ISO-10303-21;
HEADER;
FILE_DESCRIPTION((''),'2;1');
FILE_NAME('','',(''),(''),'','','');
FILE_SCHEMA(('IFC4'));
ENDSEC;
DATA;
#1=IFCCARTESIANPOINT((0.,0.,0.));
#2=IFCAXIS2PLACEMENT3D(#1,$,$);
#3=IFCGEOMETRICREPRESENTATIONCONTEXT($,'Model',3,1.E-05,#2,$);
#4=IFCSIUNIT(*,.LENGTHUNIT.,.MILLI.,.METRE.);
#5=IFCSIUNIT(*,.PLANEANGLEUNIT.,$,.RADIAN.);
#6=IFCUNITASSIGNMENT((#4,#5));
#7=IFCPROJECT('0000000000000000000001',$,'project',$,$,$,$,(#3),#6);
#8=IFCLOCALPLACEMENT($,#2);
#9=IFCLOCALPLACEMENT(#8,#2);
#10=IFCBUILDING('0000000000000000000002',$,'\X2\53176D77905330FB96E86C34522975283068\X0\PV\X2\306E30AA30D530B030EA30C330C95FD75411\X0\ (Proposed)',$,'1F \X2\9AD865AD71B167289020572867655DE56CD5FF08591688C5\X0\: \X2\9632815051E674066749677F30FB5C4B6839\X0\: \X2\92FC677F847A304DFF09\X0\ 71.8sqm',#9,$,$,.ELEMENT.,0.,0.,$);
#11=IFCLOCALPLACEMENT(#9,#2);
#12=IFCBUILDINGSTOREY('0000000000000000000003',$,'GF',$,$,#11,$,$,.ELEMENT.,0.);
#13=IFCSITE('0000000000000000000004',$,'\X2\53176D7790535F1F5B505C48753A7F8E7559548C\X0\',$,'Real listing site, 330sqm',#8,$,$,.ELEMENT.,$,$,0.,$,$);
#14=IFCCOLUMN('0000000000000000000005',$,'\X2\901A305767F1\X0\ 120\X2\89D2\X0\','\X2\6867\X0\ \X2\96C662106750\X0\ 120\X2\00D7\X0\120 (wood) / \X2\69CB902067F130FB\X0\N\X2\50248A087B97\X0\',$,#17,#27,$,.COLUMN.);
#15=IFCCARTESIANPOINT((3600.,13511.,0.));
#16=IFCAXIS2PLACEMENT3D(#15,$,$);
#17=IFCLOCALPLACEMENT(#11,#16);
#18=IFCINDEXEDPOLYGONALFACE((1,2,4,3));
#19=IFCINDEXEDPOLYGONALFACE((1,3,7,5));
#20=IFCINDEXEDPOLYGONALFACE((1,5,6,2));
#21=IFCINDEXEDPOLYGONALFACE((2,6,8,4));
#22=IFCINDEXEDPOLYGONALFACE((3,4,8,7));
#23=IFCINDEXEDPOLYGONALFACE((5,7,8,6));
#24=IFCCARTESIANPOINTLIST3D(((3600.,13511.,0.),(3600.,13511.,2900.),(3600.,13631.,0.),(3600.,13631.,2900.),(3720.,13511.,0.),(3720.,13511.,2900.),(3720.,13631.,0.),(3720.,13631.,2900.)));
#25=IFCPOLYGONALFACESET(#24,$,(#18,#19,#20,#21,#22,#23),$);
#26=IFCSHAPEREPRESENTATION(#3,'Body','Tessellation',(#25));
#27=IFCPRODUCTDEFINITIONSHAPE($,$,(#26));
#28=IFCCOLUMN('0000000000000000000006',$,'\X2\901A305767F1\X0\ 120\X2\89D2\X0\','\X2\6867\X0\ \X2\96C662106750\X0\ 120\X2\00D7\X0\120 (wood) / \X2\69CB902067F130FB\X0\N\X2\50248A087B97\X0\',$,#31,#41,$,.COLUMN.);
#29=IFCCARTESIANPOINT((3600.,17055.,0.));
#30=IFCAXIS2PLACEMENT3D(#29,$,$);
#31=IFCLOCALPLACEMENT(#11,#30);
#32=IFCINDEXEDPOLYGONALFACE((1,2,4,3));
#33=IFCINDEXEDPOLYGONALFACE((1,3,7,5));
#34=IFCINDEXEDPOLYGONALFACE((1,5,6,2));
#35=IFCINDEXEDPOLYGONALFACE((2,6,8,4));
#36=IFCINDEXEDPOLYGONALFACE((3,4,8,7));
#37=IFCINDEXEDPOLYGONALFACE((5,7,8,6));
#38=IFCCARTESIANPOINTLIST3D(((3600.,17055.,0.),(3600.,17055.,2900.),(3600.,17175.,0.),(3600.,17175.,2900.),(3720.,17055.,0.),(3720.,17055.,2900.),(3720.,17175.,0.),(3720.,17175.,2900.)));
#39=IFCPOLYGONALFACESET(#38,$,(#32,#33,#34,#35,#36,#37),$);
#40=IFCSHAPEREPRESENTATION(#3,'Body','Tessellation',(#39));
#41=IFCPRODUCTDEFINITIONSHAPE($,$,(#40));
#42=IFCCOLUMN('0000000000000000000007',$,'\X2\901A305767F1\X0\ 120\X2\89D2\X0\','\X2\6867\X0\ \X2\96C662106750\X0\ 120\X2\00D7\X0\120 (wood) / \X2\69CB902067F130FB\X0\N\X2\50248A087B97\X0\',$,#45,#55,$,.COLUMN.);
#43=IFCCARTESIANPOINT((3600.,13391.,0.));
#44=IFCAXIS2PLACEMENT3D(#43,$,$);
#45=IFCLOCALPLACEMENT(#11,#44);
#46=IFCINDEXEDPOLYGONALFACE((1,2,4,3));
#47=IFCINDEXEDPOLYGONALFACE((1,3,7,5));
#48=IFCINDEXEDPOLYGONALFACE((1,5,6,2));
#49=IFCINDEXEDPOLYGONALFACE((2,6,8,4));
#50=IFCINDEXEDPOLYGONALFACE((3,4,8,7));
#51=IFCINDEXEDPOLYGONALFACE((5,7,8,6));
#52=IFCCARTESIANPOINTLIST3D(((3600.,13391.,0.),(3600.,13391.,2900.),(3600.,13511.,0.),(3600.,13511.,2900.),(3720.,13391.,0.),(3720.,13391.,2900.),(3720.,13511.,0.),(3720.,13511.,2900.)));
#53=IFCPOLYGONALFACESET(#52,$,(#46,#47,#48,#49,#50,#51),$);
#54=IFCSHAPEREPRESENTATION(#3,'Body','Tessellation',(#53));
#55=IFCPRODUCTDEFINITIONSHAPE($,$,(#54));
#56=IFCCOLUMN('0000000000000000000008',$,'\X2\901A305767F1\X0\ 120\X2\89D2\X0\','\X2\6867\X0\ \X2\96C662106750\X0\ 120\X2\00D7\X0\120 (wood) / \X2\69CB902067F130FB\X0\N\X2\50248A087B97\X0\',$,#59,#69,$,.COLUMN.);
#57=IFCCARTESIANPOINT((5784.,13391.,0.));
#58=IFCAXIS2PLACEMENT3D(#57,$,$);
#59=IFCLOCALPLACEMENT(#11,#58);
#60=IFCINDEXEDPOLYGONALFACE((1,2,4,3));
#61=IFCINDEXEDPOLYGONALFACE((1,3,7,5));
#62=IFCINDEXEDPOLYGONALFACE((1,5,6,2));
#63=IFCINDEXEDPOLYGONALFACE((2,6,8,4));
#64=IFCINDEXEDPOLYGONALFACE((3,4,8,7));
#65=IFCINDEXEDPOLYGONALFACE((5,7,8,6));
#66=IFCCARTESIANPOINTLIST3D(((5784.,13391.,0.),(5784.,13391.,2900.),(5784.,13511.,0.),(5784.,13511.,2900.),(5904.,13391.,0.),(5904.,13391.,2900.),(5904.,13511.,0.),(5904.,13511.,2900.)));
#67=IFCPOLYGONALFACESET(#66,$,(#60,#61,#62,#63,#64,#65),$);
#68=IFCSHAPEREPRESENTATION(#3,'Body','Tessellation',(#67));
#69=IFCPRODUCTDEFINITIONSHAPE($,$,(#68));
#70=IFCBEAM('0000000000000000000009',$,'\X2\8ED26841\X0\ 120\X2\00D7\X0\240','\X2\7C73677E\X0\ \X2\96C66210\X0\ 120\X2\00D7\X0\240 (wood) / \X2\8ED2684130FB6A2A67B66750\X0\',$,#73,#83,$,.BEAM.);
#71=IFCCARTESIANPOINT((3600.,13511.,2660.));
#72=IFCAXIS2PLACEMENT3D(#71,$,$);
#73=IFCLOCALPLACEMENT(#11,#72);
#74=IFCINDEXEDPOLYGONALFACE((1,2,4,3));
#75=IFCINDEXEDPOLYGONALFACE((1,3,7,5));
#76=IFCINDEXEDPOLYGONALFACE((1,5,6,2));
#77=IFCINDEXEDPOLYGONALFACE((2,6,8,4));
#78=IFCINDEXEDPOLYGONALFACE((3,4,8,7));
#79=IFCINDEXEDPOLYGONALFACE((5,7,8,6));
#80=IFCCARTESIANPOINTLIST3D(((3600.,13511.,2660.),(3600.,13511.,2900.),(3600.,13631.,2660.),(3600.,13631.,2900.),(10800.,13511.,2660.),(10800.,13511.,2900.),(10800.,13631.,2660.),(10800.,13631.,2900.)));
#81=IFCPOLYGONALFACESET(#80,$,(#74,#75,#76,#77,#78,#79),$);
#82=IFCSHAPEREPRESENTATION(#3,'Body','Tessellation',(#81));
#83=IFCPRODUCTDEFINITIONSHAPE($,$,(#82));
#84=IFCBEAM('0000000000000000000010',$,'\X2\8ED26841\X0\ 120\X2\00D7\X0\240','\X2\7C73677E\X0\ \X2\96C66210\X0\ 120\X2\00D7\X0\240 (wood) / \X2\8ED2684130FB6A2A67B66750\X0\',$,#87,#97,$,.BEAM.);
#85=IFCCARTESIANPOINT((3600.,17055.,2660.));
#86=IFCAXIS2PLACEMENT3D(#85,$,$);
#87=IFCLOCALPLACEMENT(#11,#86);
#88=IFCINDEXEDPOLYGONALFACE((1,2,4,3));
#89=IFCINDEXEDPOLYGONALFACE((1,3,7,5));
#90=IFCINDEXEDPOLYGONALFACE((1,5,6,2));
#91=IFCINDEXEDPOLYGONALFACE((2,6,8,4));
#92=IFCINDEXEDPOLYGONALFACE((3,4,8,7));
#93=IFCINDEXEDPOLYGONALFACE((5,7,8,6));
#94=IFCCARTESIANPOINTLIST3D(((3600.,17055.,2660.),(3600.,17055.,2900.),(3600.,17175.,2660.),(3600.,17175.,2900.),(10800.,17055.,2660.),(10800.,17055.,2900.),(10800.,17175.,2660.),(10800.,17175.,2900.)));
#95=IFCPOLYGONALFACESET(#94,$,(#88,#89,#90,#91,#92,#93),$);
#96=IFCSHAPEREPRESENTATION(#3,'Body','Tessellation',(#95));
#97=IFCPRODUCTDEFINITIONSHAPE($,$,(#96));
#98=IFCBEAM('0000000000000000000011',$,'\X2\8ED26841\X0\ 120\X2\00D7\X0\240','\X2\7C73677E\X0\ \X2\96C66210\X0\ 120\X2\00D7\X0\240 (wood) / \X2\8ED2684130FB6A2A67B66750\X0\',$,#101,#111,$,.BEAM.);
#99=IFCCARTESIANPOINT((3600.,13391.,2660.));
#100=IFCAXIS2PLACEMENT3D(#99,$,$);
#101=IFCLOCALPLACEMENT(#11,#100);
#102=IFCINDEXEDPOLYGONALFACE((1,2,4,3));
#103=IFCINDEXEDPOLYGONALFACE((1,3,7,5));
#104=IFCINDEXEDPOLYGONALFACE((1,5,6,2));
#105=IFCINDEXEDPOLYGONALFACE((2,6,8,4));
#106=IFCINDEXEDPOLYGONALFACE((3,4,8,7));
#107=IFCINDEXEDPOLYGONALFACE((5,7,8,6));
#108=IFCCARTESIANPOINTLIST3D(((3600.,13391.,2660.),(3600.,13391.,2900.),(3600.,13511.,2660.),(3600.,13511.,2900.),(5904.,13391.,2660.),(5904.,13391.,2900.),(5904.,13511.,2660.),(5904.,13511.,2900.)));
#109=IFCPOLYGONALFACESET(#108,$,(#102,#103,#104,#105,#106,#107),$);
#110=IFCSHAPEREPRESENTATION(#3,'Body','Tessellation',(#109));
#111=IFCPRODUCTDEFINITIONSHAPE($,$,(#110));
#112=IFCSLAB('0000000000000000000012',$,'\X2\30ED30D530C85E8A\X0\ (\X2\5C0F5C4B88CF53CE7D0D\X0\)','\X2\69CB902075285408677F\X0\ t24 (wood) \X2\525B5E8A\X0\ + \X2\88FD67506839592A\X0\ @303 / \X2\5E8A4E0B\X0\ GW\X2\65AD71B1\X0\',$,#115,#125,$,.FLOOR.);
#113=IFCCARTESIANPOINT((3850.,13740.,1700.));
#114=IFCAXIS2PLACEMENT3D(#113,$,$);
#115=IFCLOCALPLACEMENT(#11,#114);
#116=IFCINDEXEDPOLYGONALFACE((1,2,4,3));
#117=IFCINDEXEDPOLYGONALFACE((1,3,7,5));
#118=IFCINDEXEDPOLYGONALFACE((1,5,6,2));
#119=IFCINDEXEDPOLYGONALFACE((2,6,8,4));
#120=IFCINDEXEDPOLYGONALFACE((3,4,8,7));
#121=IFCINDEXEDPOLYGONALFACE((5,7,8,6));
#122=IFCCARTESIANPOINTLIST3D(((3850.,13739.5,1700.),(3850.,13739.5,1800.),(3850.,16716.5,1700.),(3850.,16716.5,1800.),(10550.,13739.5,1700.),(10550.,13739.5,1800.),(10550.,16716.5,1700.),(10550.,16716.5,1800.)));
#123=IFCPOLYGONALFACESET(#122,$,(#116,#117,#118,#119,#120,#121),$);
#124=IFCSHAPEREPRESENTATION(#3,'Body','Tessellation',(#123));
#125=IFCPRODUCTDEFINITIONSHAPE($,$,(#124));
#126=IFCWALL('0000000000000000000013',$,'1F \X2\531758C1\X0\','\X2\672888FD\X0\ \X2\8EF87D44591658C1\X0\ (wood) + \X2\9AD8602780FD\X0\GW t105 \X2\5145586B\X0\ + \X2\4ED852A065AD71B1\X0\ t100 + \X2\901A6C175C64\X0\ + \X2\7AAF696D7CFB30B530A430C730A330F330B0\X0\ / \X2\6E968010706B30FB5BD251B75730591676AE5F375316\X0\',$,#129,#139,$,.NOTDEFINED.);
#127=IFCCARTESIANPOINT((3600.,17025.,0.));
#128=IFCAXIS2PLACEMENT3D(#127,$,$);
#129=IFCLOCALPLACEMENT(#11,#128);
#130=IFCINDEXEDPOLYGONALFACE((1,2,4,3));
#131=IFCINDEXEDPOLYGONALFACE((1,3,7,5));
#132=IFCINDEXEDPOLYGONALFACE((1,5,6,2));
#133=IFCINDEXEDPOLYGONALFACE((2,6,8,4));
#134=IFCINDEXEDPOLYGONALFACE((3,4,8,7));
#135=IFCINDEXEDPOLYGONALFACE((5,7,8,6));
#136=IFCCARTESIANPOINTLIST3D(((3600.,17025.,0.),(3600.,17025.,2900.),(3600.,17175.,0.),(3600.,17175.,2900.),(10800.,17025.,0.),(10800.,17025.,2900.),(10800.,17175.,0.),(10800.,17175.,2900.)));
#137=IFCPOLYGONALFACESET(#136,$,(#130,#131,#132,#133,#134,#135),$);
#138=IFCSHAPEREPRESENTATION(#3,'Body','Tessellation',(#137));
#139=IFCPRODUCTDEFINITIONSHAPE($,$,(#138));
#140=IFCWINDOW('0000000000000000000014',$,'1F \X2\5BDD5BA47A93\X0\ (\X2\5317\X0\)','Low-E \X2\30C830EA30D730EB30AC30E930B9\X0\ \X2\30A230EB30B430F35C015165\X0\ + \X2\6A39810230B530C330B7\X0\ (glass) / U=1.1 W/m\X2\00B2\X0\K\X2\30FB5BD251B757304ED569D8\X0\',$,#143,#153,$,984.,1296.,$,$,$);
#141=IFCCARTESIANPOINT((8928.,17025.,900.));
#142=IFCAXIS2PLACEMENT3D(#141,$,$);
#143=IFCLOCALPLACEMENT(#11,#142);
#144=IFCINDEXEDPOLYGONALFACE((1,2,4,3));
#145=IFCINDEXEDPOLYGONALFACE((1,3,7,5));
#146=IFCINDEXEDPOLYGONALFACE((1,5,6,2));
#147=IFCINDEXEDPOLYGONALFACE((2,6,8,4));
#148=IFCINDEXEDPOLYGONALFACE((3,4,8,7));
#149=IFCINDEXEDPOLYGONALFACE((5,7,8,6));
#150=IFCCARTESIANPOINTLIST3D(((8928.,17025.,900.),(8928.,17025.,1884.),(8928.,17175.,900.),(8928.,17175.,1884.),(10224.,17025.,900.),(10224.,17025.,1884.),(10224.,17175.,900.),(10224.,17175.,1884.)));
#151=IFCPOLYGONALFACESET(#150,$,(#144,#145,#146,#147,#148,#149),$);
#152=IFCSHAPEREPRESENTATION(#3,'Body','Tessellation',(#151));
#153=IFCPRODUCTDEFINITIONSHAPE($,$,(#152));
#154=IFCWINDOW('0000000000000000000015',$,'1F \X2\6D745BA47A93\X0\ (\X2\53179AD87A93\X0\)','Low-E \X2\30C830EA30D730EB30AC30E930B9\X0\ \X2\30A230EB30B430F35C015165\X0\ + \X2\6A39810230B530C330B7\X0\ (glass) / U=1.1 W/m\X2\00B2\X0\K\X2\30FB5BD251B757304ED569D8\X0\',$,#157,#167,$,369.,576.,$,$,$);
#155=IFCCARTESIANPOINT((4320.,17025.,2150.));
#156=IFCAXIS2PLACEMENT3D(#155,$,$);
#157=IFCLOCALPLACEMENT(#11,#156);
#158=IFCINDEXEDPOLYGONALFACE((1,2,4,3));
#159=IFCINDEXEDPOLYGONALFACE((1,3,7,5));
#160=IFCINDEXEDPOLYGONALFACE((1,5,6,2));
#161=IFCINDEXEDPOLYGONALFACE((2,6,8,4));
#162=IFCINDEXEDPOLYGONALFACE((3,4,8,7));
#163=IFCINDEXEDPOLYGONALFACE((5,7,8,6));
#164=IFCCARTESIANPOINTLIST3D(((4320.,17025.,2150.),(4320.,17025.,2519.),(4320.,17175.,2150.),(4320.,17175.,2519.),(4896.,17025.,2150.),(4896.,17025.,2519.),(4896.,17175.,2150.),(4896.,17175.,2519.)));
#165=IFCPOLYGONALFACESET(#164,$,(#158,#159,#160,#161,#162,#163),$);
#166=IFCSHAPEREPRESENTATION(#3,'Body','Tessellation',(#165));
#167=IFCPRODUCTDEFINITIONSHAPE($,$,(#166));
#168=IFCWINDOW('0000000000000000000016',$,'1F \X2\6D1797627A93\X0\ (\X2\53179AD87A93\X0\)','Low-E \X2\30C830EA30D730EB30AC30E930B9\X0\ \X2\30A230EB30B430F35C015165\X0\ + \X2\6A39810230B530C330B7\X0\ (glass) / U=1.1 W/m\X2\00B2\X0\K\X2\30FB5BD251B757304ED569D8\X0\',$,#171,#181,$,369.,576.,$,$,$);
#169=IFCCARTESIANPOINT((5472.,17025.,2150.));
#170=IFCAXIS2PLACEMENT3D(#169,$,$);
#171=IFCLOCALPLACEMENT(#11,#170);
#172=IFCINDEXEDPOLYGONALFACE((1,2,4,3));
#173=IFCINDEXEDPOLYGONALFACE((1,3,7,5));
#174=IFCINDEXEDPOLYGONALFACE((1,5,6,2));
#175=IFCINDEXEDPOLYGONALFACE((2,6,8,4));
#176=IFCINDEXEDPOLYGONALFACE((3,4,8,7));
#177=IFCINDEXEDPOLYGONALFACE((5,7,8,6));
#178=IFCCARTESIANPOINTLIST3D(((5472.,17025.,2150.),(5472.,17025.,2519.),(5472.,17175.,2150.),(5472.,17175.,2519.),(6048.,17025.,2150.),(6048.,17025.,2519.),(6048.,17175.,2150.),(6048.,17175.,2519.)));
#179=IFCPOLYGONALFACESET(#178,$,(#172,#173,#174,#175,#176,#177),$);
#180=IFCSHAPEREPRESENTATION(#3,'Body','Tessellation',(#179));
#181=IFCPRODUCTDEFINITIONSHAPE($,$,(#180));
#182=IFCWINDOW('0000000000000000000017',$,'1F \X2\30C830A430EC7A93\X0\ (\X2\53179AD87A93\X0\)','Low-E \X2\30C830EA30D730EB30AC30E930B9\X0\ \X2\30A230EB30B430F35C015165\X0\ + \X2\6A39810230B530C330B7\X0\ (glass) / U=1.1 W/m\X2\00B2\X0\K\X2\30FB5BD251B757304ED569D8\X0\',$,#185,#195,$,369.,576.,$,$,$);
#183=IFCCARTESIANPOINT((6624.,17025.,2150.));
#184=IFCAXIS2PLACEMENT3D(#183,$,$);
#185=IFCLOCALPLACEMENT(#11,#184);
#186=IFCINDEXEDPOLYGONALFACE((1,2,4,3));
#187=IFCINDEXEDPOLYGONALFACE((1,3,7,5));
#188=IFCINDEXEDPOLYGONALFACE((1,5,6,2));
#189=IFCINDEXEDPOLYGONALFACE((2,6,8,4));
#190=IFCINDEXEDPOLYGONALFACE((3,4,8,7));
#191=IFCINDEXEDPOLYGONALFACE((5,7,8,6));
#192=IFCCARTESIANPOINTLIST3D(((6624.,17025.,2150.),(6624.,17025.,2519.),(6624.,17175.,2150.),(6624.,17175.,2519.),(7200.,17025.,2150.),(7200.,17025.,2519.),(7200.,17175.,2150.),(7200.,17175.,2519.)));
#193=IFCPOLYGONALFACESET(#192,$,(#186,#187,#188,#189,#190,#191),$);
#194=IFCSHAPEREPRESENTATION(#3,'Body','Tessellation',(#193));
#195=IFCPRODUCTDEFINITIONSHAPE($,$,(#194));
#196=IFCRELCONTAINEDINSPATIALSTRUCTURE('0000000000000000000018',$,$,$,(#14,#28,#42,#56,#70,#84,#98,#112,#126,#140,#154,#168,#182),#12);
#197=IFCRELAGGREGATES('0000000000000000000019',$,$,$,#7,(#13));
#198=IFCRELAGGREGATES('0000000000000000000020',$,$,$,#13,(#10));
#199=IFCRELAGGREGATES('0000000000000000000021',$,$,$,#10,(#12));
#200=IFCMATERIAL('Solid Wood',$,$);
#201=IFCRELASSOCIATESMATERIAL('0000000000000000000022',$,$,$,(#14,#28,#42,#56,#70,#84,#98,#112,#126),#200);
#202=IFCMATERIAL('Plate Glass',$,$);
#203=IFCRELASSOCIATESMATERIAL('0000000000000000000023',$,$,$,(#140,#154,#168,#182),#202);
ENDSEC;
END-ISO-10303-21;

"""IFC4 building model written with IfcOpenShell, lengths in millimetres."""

from ifc_helpers import new_model, si_unit, frame, frame_2d, origin, place, context, project, spatial, rectangle, extrude, material, element, fill, save


model = new_model("IFC4")

# Units and contexts
model_context = context("Model", 3, precision=1e-05, world=origin())
ifc_project = project(units=[si_unit("LENGTHUNIT", "METRE", prefix="MILLI"), si_unit("PLANEANGLEUNIT", "RADIAN")], contexts=[model_context])

# Site, building, storey
site_placement = place(None, origin())
site = spatial("IfcSite", under=ifc_project, at=site_placement, Name="北海道弟子屈町美留和", ObjectType="Real listing site, 330sqm", CompositionType="ELEMENT", RefElevation=0.0)
building_placement = place(site_placement, origin())
building = spatial("IfcBuilding", under=site, at=building_placement, Name="北海道・雨水利用とPVのオフグリッド志向 (Proposed)", ObjectType="1F 高断熱木造在来工法（外装: 防腐処理杉板・屋根: 鋼板葺き） 71.8sqm", CompositionType="ELEMENT", ElevationOfRefHeight=0.0, ElevationOfTerrain=0.0)
storey_placement = place(building_placement, origin())
storey = spatial("IfcBuildingStorey", under=building, at=storey_placement, Name="GF", CompositionType="ELEMENT", Elevation=0.0)

# Columns
ifc_material_1 = material(Name="Solid Wood")
column_1_placement = place(storey_placement, frame((3600.0, 13511.0, 0.0)))
element("IfcColumn", 1, at=column_1_placement, inside=storey, material=ifc_material_1, Name="通し柱 120角", Description="桧 集成材 120×120 (wood) / 構造柱・N値計算", PredefinedType="COLUMN", context=model_context, shape_type="SweptSolid", body=[
    extrude(rectangle(XDim=120.0, YDim=120.0, at=frame_2d((60.0, 60.0))), frame((3600.0, 13511.0, 0.0)), (0.0, 0.0, 1.0), 2900.0),
])
column_2_placement = place(storey_placement, frame((3600.0, 17055.0, 0.0)))
element("IfcColumn", 2, at=column_2_placement, inside=storey, material=ifc_material_1, Name="通し柱 120角", Description="桧 集成材 120×120 (wood) / 構造柱・N値計算", PredefinedType="COLUMN", context=model_context, shape_type="SweptSolid", body=[
    extrude(rectangle(XDim=120.0, YDim=120.0, at=frame_2d((60.0, 60.0))), frame((3600.0, 17055.0, 0.0)), (0.0, 0.0, 1.0), 2900.0),
])
column_3_placement = place(storey_placement, frame((3600.0, 13391.0, 0.0)))
element("IfcColumn", 3, at=column_3_placement, inside=storey, material=ifc_material_1, Name="通し柱 120角", Description="桧 集成材 120×120 (wood) / 構造柱・N値計算", PredefinedType="COLUMN", context=model_context, shape_type="SweptSolid", body=[
    extrude(rectangle(XDim=120.0, YDim=120.0, at=frame_2d((60.0, 60.0))), frame((3600.0, 13391.0, 0.0)), (0.0, 0.0, 1.0), 2900.0),
])
column_4_placement = place(storey_placement, frame((5784.0, 13391.0, 0.0)))
element("IfcColumn", 4, at=column_4_placement, inside=storey, material=ifc_material_1, Name="通し柱 120角", Description="桧 集成材 120×120 (wood) / 構造柱・N値計算", PredefinedType="COLUMN", context=model_context, shape_type="SweptSolid", body=[
    extrude(rectangle(XDim=120.0, YDim=120.0, at=frame_2d((60.0, 60.0))), frame((5784.0, 13391.0, 0.0)), (0.0, 0.0, 1.0), 2900.0),
])

# Beams
beam_1_placement = place(storey_placement, frame((3600.0, 13511.0, 2660.0)))
element("IfcBeam", 5, at=beam_1_placement, inside=storey, material=ifc_material_1, Name="軒桁 120×240", Description="米松 集成 120×240 (wood) / 軒桁・横架材", PredefinedType="BEAM", context=model_context, shape_type="SweptSolid", body=[
    extrude(rectangle(XDim=7200.0, YDim=120.0, at=frame_2d((3600.0, 60.0))), frame((3600.0, 13511.0, 2660.0)), (0.0, 0.0, 1.0), 240.0),
])
beam_2_placement = place(storey_placement, frame((3600.0, 17055.0, 2660.0)))
element("IfcBeam", 6, at=beam_2_placement, inside=storey, material=ifc_material_1, Name="軒桁 120×240", Description="米松 集成 120×240 (wood) / 軒桁・横架材", PredefinedType="BEAM", context=model_context, shape_type="SweptSolid", body=[
    extrude(rectangle(XDim=7200.0, YDim=120.0, at=frame_2d((3600.0, 60.0))), frame((3600.0, 17055.0, 2660.0)), (0.0, 0.0, 1.0), 240.0),
])
beam_3_placement = place(storey_placement, frame((3600.0, 13391.0, 2660.0)))
element("IfcBeam", 7, at=beam_3_placement, inside=storey, material=ifc_material_1, Name="軒桁 120×240", Description="米松 集成 120×240 (wood) / 軒桁・横架材", PredefinedType="BEAM", context=model_context, shape_type="SweptSolid", body=[
    extrude(rectangle(XDim=2304.0, YDim=120.0, at=frame_2d((1152.0, 60.0))), frame((3600.0, 13391.0, 2660.0)), (0.0, 0.0, 1.0), 240.0),
])

# Slab
slab_1_placement = place(storey_placement, frame((3850.0, 13740.0, 1700.0)))
element("IfcSlab", 8, at=slab_1_placement, inside=storey, material=ifc_material_1, Name="ロフト床 (小屋裏収納)", Description="構造用合板 t24 (wood) 剛床 + 製材根太 @303 / 床下 GW断熱", PredefinedType="FLOOR", context=model_context, shape_type="SweptSolid", body=[
    extrude(rectangle(XDim=6700.0, YDim=2977.0, at=frame_2d((3350.0, 1488.0))), frame((3850.0, 13740.0, 1700.0)), (0.0, 0.0, 1.0), 100.0),
])

# Wall, openings, windows
wall_1_placement = place(storey_placement, frame((3600.0, 17025.0, 0.0)))
wall_1 = element("IfcWall", 9, at=wall_1_placement, inside=storey, material=ifc_material_1, Name="1F 北壁", Description="木製 軸組外壁 (wood) + 高性能GW t105 充填 + 付加断熱 t100 + 通気層 + 窯業系サイディング / 準耐火・寒冷地外皮強化", PredefinedType="NOTDEFINED", context=model_context, shape_type="SweptSolid", body=[
    extrude(rectangle(XDim=7200.0, YDim=150.0, at=frame_2d((3600.0, 75.0))), frame((3600.0, 17025.0, 0.0)), (0.0, 0.0, 1.0), 2900.0),
])
opening_1_placement = place(storey_placement, frame((8928.0, 17025.0, 900.0)))
opening_1 = element("IfcOpeningElement", 10, at=opening_1_placement, cuts=wall_1, PredefinedType="NOTDEFINED", context=model_context, shape_type="SweptSolid", body=[
    extrude(rectangle(XDim=1296.0, YDim=150.0, at=frame_2d((648.0, 75.0))), frame((8928.0, 17025.0, 900.0)), (0.0, 0.0, 1.0), 984.0),
])
opening_2_placement = place(storey_placement, frame((4320.0, 17025.0, 2150.0)))
opening_2 = element("IfcOpeningElement", 11, at=opening_2_placement, cuts=wall_1, PredefinedType="NOTDEFINED", context=model_context, shape_type="SweptSolid", body=[
    extrude(rectangle(XDim=576.0, YDim=150.0, at=frame_2d((288.0, 75.0))), frame((4320.0, 17025.0, 2150.0)), (0.0, 0.0, 1.0), 369.0),
])
opening_3_placement = place(storey_placement, frame((5472.0, 17025.0, 2150.0)))
opening_3 = element("IfcOpeningElement", 12, at=opening_3_placement, cuts=wall_1, PredefinedType="NOTDEFINED", context=model_context, shape_type="SweptSolid", body=[
    extrude(rectangle(XDim=576.0, YDim=150.0, at=frame_2d((288.0, 75.0))), frame((5472.0, 17025.0, 2150.0)), (0.0, 0.0, 1.0), 369.0),
])
opening_4_placement = place(storey_placement, frame((6624.0, 17025.0, 2150.0)))
opening_4 = element("IfcOpeningElement", 13, at=opening_4_placement, cuts=wall_1, PredefinedType="NOTDEFINED", context=model_context, shape_type="SweptSolid", body=[
    extrude(rectangle(XDim=576.0, YDim=150.0, at=frame_2d((288.0, 75.0))), frame((6624.0, 17025.0, 2150.0)), (0.0, 0.0, 1.0), 369.0),
])
ifc_material_2 = material(Name="Plate Glass")
window_1_placement = place(storey_placement, frame((8928.0, 17025.0, 900.0)))
window_1 = element("IfcWindow", 14, at=window_1_placement, inside=storey, material=ifc_material_2, Name="1F 寝室窓 (北)", Description="Low-E トリプルガラス アルゴン封入 + 樹脂サッシ (glass) / U=1.1 W/m²K・寒冷地仕様", OverallHeight=984.0, OverallWidth=1296.0, context=model_context, shape_type="SweptSolid", body=[
    extrude(rectangle(XDim=1296.0, YDim=150.0, at=frame_2d((648.0, 75.0))), frame((8928.0, 17025.0, 900.0)), (0.0, 0.0, 1.0), 984.0),
])
fill(opening_1, window_1)
window_2_placement = place(storey_placement, frame((4320.0, 17025.0, 2150.0)))
window_2 = element("IfcWindow", 15, at=window_2_placement, inside=storey, material=ifc_material_2, Name="1F 浴室窓 (北高窓)", Description="Low-E トリプルガラス アルゴン封入 + 樹脂サッシ (glass) / U=1.1 W/m²K・寒冷地仕様", OverallHeight=369.0, OverallWidth=576.0, context=model_context, shape_type="SweptSolid", body=[
    extrude(rectangle(XDim=576.0, YDim=150.0, at=frame_2d((288.0, 75.0))), frame((4320.0, 17025.0, 2150.0)), (0.0, 0.0, 1.0), 369.0),
])
fill(opening_2, window_2)
window_3_placement = place(storey_placement, frame((5472.0, 17025.0, 2150.0)))
window_3 = element("IfcWindow", 16, at=window_3_placement, inside=storey, material=ifc_material_2, Name="1F 洗面窓 (北高窓)", Description="Low-E トリプルガラス アルゴン封入 + 樹脂サッシ (glass) / U=1.1 W/m²K・寒冷地仕様", OverallHeight=369.0, OverallWidth=576.0, context=model_context, shape_type="SweptSolid", body=[
    extrude(rectangle(XDim=576.0, YDim=150.0, at=frame_2d((288.0, 75.0))), frame((5472.0, 17025.0, 2150.0)), (0.0, 0.0, 1.0), 369.0),
])
fill(opening_3, window_3)
window_4_placement = place(storey_placement, frame((6624.0, 17025.0, 2150.0)))
window_4 = element("IfcWindow", 17, at=window_4_placement, inside=storey, material=ifc_material_2, Name="1F トイレ窓 (北高窓)", Description="Low-E トリプルガラス アルゴン封入 + 樹脂サッシ (glass) / U=1.1 W/m²K・寒冷地仕様", OverallHeight=369.0, OverallWidth=576.0, context=model_context, shape_type="SweptSolid", body=[
    extrude(rectangle(XDim=576.0, YDim=150.0, at=frame_2d((288.0, 75.0))), frame((6624.0, 17025.0, 2150.0)), (0.0, 0.0, 1.0), 369.0),
])
fill(opening_4, window_4)

save(model, "model.ifc")
